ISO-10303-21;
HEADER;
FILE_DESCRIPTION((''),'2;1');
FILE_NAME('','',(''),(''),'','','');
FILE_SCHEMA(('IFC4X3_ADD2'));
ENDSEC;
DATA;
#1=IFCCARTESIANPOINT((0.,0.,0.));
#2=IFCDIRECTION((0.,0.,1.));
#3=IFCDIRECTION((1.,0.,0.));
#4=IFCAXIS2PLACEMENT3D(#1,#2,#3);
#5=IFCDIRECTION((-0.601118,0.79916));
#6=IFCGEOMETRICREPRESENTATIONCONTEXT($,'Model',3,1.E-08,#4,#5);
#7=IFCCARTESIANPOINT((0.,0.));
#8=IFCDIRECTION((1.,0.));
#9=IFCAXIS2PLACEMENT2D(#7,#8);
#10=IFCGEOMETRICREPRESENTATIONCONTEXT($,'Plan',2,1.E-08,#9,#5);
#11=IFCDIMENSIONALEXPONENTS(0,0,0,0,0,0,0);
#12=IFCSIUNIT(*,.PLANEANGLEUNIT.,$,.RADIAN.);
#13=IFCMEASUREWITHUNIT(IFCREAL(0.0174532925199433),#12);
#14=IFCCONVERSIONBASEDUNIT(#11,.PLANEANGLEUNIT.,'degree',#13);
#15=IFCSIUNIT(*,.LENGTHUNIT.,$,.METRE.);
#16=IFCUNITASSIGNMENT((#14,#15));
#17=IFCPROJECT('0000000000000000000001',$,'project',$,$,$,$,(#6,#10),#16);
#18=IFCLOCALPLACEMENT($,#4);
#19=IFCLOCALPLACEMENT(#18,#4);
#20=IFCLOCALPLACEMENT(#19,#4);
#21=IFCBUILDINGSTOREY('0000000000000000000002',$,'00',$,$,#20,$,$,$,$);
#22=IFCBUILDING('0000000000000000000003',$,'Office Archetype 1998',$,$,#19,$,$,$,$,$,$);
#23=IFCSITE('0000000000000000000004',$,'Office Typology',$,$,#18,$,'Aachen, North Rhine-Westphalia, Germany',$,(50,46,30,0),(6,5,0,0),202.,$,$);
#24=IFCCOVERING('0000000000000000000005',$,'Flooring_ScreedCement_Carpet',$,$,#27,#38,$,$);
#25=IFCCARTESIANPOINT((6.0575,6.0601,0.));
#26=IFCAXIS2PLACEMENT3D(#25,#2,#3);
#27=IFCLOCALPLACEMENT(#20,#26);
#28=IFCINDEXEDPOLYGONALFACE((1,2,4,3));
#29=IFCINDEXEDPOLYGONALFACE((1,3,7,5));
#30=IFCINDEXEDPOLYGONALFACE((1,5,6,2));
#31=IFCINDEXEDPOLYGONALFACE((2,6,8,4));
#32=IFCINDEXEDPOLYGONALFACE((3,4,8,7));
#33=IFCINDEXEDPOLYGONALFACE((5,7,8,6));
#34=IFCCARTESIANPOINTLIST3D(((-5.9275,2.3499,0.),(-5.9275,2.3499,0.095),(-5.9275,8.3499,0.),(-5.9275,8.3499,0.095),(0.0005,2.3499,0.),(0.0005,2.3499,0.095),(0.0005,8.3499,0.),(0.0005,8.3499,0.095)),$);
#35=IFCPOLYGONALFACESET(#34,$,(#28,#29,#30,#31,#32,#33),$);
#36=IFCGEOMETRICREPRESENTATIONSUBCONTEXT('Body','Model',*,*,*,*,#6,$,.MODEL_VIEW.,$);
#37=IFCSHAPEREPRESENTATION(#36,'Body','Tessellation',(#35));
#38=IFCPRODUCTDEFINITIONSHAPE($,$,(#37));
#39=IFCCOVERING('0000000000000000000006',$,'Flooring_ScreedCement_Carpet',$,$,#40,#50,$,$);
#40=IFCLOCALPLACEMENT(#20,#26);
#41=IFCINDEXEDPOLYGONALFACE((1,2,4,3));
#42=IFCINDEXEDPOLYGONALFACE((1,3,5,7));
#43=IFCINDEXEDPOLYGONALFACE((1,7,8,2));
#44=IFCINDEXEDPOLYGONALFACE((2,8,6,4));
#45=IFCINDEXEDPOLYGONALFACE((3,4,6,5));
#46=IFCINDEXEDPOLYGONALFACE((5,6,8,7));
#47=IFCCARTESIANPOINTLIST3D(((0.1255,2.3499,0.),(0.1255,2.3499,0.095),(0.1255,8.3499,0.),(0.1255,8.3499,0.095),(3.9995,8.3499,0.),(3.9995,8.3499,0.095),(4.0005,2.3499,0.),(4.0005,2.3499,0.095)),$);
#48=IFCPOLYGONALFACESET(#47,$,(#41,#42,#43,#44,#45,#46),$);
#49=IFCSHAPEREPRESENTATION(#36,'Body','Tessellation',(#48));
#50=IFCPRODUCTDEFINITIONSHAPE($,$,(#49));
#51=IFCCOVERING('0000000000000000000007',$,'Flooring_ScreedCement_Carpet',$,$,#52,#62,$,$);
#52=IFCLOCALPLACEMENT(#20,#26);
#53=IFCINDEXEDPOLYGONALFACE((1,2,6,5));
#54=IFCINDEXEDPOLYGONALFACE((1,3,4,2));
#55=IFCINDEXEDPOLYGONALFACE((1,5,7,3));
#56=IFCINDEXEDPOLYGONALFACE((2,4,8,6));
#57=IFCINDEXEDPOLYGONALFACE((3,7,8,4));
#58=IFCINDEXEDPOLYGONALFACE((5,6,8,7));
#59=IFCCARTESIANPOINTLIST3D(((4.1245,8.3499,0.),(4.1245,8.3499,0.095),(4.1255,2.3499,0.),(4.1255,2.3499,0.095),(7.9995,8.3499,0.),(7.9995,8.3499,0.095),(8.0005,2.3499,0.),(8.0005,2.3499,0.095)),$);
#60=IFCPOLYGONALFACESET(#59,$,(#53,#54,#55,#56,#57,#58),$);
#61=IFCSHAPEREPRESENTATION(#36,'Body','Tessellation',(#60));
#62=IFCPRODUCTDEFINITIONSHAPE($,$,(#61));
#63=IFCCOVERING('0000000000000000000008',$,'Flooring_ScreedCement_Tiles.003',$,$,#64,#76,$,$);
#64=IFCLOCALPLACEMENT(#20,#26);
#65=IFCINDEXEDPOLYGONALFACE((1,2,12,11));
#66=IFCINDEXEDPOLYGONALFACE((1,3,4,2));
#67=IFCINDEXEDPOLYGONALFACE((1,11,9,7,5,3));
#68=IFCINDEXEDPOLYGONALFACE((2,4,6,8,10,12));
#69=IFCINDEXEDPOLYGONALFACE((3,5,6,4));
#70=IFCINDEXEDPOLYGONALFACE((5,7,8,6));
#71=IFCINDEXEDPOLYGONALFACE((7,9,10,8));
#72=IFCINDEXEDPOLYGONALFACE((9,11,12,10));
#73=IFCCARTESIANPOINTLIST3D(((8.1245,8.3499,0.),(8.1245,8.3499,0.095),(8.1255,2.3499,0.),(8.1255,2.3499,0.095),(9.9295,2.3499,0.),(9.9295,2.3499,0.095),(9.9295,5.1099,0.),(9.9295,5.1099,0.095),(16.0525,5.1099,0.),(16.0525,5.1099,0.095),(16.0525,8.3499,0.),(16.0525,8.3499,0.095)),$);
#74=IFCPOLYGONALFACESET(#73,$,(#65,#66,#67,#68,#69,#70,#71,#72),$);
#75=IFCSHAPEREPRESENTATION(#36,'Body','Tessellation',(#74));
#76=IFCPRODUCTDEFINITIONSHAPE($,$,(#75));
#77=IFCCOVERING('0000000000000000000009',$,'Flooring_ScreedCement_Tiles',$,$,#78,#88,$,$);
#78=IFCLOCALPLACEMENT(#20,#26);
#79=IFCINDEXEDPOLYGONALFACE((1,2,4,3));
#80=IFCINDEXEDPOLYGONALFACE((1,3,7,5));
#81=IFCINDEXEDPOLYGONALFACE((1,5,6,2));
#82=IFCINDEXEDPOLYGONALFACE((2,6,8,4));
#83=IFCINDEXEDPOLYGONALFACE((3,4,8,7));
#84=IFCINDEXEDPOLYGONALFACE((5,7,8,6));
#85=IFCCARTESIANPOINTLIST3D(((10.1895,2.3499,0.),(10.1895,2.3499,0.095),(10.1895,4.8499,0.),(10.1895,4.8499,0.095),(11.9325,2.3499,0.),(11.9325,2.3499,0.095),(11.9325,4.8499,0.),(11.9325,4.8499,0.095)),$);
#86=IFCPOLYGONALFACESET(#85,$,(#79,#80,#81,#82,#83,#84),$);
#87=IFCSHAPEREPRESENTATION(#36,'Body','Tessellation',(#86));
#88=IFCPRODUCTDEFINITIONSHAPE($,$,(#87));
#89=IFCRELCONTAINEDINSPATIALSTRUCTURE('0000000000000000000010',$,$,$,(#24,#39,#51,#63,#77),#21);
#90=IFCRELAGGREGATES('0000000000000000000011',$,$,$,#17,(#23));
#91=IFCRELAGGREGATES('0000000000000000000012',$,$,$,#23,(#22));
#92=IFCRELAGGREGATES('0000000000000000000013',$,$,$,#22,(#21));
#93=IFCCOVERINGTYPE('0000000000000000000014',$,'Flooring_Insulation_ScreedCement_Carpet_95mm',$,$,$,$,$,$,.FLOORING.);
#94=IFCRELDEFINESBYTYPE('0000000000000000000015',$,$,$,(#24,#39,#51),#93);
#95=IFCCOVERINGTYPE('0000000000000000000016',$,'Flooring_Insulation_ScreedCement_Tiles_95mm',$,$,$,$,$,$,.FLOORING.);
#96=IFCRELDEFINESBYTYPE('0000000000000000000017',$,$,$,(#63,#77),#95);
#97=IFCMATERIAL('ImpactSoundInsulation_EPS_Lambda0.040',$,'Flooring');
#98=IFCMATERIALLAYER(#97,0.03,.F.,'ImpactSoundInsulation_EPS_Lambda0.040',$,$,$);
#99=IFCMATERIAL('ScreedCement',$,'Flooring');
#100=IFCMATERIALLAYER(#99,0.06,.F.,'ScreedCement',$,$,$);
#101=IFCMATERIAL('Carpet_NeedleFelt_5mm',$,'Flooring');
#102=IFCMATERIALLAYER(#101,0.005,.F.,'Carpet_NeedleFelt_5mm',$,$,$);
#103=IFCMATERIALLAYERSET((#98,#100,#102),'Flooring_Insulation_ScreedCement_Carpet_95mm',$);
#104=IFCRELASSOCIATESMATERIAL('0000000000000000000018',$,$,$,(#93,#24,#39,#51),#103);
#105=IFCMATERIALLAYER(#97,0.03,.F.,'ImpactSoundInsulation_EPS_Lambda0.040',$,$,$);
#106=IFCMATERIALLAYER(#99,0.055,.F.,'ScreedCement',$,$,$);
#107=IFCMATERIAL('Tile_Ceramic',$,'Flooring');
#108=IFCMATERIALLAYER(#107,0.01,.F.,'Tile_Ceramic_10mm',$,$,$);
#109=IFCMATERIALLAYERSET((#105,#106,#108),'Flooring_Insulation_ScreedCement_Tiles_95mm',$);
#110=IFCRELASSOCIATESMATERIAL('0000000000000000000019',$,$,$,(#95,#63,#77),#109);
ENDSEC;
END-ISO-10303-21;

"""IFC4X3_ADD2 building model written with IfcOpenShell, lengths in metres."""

from ifc_helpers import new_model, entity, si_unit, converted_unit, direction, frame, origin_with_axes, origin_2d_with_axis, place, context, subcontext, project, spatial, line, indexed_curve, outline, extrude, material, layer, layer_set, layer_usage, type_object, element, save


model = new_model("IFC4X3_ADD2")

# Units and contexts
model_context = context("Model", 3, precision=1e-08, world=origin_with_axes(), true_north=direction((-0.601118, 0.79916)))
plan_context = context("Plan", 2, precision=1e-08, world=origin_2d_with_axis(), true_north=direction((-0.601118, 0.79916)))
body_context = subcontext(model_context, "Body", "Model", "MODEL_VIEW")
ifc_project = project(units=[converted_unit("PLANEANGLEUNIT", "degree", entity("IfcReal", 0.0174532925199433), si_unit("PLANEANGLEUNIT", "RADIAN"), dimensions=[0, 0, 0, 0, 0, 0, 0]), si_unit("LENGTHUNIT", "METRE")], contexts=[model_context, plan_context])

# Site, building, storey
site_placement = place(None, origin_with_axes())
site = spatial("IfcSite", under=ifc_project, at=site_placement, Name="Office Typology", LongName="Aachen, North Rhine-Westphalia, Germany", RefLatitude=(50, 46, 30, 0), RefLongitude=(6, 5, 0, 0), RefElevation=202.0)
building_placement = place(site_placement, origin_with_axes())
building = spatial("IfcBuilding", under=site, at=building_placement, Name="Office Archetype 1998")
storey_placement = place(building_placement, origin_with_axes())
storey = spatial("IfcBuildingStorey", under=building, at=storey_placement, Name="00")

# Coverings
ifc_material_1 = material(Name="ImpactSoundInsulation_EPS_Lambda0.040", Category="Flooring")
ifc_layer_1 = layer(ifc_material_1, 0.03, ventilated=False, Name="ImpactSoundInsulation_EPS_Lambda0.040")
ifc_material_2 = material(Name="ScreedCement", Category="Flooring")
ifc_layer_2 = layer(ifc_material_2, 0.06, ventilated=False, Name="ScreedCement")
ifc_material_3 = material(Name="Carpet_NeedleFelt_5mm", Category="Flooring")
ifc_layer_3 = layer(ifc_material_3, 0.005, ventilated=False, Name="Carpet_NeedleFelt_5mm")
ifc_layer_set_1 = layer_set([ifc_layer_1, ifc_layer_2, ifc_layer_3], Name="Flooring_Insulation_ScreedCement_Carpet_95mm")
ifc_layer_usage_1 = layer_usage(ifc_layer_set_1, "AXIS3", "POSITIVE", 0.0)
covering_type_1 = type_object("IfcCoveringType", Name="Flooring_Insulation_ScreedCement_Carpet_95mm", PredefinedType="FLOORING", material=ifc_layer_set_1)
covering_1_placement = place(storey_placement, frame((6.0575, 6.0601, 0.0), z_axis=(0.0, 0.0, 1.0), x_axis=(1.0, 0.0, 0.0)))
element("IfcCovering", 1, at=covering_1_placement, inside=storey, type_object=covering_type_1, material=ifc_layer_usage_1, Name="Flooring_ScreedCement_Carpet", context=body_context, shape_type="SweptSolid", body=[
    extrude(outline(indexed_curve([(-5.9275, 2.3499), (-5.9275, 8.3499), (0.0005, 8.3499), (0.0005, 2.3499)], segments=[line(1, 2, 3, 4, 1)])), origin_with_axes(), (0.0, 0.0, 1.0), 0.095),
])
ifc_layer_usage_2 = layer_usage(ifc_layer_set_1, "AXIS3", "POSITIVE", 0.0)
covering_2_placement = place(storey_placement, frame((6.0575, 6.0601, 0.0), z_axis=(0.0, 0.0, 1.0), x_axis=(1.0, 0.0, 0.0)))
element("IfcCovering", 2, at=covering_2_placement, inside=storey, type_object=covering_type_1, material=ifc_layer_usage_2, Name="Flooring_ScreedCement_Carpet", context=body_context, shape_type="SweptSolid", body=[
    extrude(outline(indexed_curve([(0.1255, 2.3499), (0.1255, 8.3499), (3.9995, 8.3499), (4.0005, 2.3499)], segments=[line(1, 2, 3, 4, 1)])), origin_with_axes(), (0.0, 0.0, 1.0), 0.095),
])
ifc_layer_usage_3 = layer_usage(ifc_layer_set_1, "AXIS3", "POSITIVE", 0.0)
covering_3_placement = place(storey_placement, frame((6.0575, 6.0601, 0.0), z_axis=(0.0, 0.0, 1.0), x_axis=(1.0, 0.0, 0.0)))
element("IfcCovering", 3, at=covering_3_placement, inside=storey, type_object=covering_type_1, material=ifc_layer_usage_3, Name="Flooring_ScreedCement_Carpet", context=body_context, shape_type="SweptSolid", body=[
    extrude(outline(indexed_curve([(4.1255, 2.3499), (4.1245, 8.3499), (7.9995, 8.3499), (8.0005, 2.3499)], segments=[line(1, 2, 3, 4, 1)])), origin_with_axes(), (0.0, 0.0, 1.0), 0.095),
])
ifc_layer_4 = layer(ifc_material_1, 0.03, ventilated=False, Name="ImpactSoundInsulation_EPS_Lambda0.040")
ifc_layer_5 = layer(ifc_material_2, 0.055, ventilated=False, Name="ScreedCement")
ifc_material_4 = material(Name="Tile_Ceramic", Category="Flooring")
ifc_layer_6 = layer(ifc_material_4, 0.01, ventilated=False, Name="Tile_Ceramic_10mm")
ifc_layer_set_2 = layer_set([ifc_layer_4, ifc_layer_5, ifc_layer_6], Name="Flooring_Insulation_ScreedCement_Tiles_95mm")
ifc_layer_usage_4 = layer_usage(ifc_layer_set_2, "AXIS3", "POSITIVE", 0.0)
covering_type_2 = type_object("IfcCoveringType", Name="Flooring_Insulation_ScreedCement_Tiles_95mm", PredefinedType="FLOORING", material=ifc_layer_set_2)
covering_4_placement = place(storey_placement, frame((6.0575, 6.0601, 0.0), z_axis=(0.0, 0.0, 1.0), x_axis=(1.0, 0.0, 0.0)))
element("IfcCovering", 4, at=covering_4_placement, inside=storey, type_object=covering_type_2, material=ifc_layer_usage_4, Name="Flooring_ScreedCement_Tiles.003", context=body_context, shape_type="SweptSolid", body=[
    extrude(outline(indexed_curve([(9.9295, 2.3499), (8.1255, 2.3499), (8.1245, 8.3499), (16.0525, 8.3499), (16.0525, 5.1099), (9.9295, 5.1099)], segments=[line(1, 2, 3, 4, 5, 6, 1)])), None, (0.0, 0.0, 1.0), 0.095),
])
ifc_layer_usage_5 = layer_usage(ifc_layer_set_2, "AXIS3", "POSITIVE", 0.0)
covering_5_placement = place(storey_placement, frame((6.0575, 6.0601, 0.0), z_axis=(0.0, 0.0, 1.0), x_axis=(1.0, 0.0, 0.0)))
element("IfcCovering", 5, at=covering_5_placement, inside=storey, type_object=covering_type_2, material=ifc_layer_usage_5, Name="Flooring_ScreedCement_Tiles", context=body_context, shape_type="SweptSolid", body=[
    extrude(outline(indexed_curve([(11.9325, 4.8499), (11.9325, 2.3499), (10.1895, 2.3499), (10.1895, 4.8499)], segments=[line(1, 2, 3, 4, 1)])), origin_with_axes(), (0.0, 0.0, 1.0), 0.095),
])

save(model, "model.ifc")
